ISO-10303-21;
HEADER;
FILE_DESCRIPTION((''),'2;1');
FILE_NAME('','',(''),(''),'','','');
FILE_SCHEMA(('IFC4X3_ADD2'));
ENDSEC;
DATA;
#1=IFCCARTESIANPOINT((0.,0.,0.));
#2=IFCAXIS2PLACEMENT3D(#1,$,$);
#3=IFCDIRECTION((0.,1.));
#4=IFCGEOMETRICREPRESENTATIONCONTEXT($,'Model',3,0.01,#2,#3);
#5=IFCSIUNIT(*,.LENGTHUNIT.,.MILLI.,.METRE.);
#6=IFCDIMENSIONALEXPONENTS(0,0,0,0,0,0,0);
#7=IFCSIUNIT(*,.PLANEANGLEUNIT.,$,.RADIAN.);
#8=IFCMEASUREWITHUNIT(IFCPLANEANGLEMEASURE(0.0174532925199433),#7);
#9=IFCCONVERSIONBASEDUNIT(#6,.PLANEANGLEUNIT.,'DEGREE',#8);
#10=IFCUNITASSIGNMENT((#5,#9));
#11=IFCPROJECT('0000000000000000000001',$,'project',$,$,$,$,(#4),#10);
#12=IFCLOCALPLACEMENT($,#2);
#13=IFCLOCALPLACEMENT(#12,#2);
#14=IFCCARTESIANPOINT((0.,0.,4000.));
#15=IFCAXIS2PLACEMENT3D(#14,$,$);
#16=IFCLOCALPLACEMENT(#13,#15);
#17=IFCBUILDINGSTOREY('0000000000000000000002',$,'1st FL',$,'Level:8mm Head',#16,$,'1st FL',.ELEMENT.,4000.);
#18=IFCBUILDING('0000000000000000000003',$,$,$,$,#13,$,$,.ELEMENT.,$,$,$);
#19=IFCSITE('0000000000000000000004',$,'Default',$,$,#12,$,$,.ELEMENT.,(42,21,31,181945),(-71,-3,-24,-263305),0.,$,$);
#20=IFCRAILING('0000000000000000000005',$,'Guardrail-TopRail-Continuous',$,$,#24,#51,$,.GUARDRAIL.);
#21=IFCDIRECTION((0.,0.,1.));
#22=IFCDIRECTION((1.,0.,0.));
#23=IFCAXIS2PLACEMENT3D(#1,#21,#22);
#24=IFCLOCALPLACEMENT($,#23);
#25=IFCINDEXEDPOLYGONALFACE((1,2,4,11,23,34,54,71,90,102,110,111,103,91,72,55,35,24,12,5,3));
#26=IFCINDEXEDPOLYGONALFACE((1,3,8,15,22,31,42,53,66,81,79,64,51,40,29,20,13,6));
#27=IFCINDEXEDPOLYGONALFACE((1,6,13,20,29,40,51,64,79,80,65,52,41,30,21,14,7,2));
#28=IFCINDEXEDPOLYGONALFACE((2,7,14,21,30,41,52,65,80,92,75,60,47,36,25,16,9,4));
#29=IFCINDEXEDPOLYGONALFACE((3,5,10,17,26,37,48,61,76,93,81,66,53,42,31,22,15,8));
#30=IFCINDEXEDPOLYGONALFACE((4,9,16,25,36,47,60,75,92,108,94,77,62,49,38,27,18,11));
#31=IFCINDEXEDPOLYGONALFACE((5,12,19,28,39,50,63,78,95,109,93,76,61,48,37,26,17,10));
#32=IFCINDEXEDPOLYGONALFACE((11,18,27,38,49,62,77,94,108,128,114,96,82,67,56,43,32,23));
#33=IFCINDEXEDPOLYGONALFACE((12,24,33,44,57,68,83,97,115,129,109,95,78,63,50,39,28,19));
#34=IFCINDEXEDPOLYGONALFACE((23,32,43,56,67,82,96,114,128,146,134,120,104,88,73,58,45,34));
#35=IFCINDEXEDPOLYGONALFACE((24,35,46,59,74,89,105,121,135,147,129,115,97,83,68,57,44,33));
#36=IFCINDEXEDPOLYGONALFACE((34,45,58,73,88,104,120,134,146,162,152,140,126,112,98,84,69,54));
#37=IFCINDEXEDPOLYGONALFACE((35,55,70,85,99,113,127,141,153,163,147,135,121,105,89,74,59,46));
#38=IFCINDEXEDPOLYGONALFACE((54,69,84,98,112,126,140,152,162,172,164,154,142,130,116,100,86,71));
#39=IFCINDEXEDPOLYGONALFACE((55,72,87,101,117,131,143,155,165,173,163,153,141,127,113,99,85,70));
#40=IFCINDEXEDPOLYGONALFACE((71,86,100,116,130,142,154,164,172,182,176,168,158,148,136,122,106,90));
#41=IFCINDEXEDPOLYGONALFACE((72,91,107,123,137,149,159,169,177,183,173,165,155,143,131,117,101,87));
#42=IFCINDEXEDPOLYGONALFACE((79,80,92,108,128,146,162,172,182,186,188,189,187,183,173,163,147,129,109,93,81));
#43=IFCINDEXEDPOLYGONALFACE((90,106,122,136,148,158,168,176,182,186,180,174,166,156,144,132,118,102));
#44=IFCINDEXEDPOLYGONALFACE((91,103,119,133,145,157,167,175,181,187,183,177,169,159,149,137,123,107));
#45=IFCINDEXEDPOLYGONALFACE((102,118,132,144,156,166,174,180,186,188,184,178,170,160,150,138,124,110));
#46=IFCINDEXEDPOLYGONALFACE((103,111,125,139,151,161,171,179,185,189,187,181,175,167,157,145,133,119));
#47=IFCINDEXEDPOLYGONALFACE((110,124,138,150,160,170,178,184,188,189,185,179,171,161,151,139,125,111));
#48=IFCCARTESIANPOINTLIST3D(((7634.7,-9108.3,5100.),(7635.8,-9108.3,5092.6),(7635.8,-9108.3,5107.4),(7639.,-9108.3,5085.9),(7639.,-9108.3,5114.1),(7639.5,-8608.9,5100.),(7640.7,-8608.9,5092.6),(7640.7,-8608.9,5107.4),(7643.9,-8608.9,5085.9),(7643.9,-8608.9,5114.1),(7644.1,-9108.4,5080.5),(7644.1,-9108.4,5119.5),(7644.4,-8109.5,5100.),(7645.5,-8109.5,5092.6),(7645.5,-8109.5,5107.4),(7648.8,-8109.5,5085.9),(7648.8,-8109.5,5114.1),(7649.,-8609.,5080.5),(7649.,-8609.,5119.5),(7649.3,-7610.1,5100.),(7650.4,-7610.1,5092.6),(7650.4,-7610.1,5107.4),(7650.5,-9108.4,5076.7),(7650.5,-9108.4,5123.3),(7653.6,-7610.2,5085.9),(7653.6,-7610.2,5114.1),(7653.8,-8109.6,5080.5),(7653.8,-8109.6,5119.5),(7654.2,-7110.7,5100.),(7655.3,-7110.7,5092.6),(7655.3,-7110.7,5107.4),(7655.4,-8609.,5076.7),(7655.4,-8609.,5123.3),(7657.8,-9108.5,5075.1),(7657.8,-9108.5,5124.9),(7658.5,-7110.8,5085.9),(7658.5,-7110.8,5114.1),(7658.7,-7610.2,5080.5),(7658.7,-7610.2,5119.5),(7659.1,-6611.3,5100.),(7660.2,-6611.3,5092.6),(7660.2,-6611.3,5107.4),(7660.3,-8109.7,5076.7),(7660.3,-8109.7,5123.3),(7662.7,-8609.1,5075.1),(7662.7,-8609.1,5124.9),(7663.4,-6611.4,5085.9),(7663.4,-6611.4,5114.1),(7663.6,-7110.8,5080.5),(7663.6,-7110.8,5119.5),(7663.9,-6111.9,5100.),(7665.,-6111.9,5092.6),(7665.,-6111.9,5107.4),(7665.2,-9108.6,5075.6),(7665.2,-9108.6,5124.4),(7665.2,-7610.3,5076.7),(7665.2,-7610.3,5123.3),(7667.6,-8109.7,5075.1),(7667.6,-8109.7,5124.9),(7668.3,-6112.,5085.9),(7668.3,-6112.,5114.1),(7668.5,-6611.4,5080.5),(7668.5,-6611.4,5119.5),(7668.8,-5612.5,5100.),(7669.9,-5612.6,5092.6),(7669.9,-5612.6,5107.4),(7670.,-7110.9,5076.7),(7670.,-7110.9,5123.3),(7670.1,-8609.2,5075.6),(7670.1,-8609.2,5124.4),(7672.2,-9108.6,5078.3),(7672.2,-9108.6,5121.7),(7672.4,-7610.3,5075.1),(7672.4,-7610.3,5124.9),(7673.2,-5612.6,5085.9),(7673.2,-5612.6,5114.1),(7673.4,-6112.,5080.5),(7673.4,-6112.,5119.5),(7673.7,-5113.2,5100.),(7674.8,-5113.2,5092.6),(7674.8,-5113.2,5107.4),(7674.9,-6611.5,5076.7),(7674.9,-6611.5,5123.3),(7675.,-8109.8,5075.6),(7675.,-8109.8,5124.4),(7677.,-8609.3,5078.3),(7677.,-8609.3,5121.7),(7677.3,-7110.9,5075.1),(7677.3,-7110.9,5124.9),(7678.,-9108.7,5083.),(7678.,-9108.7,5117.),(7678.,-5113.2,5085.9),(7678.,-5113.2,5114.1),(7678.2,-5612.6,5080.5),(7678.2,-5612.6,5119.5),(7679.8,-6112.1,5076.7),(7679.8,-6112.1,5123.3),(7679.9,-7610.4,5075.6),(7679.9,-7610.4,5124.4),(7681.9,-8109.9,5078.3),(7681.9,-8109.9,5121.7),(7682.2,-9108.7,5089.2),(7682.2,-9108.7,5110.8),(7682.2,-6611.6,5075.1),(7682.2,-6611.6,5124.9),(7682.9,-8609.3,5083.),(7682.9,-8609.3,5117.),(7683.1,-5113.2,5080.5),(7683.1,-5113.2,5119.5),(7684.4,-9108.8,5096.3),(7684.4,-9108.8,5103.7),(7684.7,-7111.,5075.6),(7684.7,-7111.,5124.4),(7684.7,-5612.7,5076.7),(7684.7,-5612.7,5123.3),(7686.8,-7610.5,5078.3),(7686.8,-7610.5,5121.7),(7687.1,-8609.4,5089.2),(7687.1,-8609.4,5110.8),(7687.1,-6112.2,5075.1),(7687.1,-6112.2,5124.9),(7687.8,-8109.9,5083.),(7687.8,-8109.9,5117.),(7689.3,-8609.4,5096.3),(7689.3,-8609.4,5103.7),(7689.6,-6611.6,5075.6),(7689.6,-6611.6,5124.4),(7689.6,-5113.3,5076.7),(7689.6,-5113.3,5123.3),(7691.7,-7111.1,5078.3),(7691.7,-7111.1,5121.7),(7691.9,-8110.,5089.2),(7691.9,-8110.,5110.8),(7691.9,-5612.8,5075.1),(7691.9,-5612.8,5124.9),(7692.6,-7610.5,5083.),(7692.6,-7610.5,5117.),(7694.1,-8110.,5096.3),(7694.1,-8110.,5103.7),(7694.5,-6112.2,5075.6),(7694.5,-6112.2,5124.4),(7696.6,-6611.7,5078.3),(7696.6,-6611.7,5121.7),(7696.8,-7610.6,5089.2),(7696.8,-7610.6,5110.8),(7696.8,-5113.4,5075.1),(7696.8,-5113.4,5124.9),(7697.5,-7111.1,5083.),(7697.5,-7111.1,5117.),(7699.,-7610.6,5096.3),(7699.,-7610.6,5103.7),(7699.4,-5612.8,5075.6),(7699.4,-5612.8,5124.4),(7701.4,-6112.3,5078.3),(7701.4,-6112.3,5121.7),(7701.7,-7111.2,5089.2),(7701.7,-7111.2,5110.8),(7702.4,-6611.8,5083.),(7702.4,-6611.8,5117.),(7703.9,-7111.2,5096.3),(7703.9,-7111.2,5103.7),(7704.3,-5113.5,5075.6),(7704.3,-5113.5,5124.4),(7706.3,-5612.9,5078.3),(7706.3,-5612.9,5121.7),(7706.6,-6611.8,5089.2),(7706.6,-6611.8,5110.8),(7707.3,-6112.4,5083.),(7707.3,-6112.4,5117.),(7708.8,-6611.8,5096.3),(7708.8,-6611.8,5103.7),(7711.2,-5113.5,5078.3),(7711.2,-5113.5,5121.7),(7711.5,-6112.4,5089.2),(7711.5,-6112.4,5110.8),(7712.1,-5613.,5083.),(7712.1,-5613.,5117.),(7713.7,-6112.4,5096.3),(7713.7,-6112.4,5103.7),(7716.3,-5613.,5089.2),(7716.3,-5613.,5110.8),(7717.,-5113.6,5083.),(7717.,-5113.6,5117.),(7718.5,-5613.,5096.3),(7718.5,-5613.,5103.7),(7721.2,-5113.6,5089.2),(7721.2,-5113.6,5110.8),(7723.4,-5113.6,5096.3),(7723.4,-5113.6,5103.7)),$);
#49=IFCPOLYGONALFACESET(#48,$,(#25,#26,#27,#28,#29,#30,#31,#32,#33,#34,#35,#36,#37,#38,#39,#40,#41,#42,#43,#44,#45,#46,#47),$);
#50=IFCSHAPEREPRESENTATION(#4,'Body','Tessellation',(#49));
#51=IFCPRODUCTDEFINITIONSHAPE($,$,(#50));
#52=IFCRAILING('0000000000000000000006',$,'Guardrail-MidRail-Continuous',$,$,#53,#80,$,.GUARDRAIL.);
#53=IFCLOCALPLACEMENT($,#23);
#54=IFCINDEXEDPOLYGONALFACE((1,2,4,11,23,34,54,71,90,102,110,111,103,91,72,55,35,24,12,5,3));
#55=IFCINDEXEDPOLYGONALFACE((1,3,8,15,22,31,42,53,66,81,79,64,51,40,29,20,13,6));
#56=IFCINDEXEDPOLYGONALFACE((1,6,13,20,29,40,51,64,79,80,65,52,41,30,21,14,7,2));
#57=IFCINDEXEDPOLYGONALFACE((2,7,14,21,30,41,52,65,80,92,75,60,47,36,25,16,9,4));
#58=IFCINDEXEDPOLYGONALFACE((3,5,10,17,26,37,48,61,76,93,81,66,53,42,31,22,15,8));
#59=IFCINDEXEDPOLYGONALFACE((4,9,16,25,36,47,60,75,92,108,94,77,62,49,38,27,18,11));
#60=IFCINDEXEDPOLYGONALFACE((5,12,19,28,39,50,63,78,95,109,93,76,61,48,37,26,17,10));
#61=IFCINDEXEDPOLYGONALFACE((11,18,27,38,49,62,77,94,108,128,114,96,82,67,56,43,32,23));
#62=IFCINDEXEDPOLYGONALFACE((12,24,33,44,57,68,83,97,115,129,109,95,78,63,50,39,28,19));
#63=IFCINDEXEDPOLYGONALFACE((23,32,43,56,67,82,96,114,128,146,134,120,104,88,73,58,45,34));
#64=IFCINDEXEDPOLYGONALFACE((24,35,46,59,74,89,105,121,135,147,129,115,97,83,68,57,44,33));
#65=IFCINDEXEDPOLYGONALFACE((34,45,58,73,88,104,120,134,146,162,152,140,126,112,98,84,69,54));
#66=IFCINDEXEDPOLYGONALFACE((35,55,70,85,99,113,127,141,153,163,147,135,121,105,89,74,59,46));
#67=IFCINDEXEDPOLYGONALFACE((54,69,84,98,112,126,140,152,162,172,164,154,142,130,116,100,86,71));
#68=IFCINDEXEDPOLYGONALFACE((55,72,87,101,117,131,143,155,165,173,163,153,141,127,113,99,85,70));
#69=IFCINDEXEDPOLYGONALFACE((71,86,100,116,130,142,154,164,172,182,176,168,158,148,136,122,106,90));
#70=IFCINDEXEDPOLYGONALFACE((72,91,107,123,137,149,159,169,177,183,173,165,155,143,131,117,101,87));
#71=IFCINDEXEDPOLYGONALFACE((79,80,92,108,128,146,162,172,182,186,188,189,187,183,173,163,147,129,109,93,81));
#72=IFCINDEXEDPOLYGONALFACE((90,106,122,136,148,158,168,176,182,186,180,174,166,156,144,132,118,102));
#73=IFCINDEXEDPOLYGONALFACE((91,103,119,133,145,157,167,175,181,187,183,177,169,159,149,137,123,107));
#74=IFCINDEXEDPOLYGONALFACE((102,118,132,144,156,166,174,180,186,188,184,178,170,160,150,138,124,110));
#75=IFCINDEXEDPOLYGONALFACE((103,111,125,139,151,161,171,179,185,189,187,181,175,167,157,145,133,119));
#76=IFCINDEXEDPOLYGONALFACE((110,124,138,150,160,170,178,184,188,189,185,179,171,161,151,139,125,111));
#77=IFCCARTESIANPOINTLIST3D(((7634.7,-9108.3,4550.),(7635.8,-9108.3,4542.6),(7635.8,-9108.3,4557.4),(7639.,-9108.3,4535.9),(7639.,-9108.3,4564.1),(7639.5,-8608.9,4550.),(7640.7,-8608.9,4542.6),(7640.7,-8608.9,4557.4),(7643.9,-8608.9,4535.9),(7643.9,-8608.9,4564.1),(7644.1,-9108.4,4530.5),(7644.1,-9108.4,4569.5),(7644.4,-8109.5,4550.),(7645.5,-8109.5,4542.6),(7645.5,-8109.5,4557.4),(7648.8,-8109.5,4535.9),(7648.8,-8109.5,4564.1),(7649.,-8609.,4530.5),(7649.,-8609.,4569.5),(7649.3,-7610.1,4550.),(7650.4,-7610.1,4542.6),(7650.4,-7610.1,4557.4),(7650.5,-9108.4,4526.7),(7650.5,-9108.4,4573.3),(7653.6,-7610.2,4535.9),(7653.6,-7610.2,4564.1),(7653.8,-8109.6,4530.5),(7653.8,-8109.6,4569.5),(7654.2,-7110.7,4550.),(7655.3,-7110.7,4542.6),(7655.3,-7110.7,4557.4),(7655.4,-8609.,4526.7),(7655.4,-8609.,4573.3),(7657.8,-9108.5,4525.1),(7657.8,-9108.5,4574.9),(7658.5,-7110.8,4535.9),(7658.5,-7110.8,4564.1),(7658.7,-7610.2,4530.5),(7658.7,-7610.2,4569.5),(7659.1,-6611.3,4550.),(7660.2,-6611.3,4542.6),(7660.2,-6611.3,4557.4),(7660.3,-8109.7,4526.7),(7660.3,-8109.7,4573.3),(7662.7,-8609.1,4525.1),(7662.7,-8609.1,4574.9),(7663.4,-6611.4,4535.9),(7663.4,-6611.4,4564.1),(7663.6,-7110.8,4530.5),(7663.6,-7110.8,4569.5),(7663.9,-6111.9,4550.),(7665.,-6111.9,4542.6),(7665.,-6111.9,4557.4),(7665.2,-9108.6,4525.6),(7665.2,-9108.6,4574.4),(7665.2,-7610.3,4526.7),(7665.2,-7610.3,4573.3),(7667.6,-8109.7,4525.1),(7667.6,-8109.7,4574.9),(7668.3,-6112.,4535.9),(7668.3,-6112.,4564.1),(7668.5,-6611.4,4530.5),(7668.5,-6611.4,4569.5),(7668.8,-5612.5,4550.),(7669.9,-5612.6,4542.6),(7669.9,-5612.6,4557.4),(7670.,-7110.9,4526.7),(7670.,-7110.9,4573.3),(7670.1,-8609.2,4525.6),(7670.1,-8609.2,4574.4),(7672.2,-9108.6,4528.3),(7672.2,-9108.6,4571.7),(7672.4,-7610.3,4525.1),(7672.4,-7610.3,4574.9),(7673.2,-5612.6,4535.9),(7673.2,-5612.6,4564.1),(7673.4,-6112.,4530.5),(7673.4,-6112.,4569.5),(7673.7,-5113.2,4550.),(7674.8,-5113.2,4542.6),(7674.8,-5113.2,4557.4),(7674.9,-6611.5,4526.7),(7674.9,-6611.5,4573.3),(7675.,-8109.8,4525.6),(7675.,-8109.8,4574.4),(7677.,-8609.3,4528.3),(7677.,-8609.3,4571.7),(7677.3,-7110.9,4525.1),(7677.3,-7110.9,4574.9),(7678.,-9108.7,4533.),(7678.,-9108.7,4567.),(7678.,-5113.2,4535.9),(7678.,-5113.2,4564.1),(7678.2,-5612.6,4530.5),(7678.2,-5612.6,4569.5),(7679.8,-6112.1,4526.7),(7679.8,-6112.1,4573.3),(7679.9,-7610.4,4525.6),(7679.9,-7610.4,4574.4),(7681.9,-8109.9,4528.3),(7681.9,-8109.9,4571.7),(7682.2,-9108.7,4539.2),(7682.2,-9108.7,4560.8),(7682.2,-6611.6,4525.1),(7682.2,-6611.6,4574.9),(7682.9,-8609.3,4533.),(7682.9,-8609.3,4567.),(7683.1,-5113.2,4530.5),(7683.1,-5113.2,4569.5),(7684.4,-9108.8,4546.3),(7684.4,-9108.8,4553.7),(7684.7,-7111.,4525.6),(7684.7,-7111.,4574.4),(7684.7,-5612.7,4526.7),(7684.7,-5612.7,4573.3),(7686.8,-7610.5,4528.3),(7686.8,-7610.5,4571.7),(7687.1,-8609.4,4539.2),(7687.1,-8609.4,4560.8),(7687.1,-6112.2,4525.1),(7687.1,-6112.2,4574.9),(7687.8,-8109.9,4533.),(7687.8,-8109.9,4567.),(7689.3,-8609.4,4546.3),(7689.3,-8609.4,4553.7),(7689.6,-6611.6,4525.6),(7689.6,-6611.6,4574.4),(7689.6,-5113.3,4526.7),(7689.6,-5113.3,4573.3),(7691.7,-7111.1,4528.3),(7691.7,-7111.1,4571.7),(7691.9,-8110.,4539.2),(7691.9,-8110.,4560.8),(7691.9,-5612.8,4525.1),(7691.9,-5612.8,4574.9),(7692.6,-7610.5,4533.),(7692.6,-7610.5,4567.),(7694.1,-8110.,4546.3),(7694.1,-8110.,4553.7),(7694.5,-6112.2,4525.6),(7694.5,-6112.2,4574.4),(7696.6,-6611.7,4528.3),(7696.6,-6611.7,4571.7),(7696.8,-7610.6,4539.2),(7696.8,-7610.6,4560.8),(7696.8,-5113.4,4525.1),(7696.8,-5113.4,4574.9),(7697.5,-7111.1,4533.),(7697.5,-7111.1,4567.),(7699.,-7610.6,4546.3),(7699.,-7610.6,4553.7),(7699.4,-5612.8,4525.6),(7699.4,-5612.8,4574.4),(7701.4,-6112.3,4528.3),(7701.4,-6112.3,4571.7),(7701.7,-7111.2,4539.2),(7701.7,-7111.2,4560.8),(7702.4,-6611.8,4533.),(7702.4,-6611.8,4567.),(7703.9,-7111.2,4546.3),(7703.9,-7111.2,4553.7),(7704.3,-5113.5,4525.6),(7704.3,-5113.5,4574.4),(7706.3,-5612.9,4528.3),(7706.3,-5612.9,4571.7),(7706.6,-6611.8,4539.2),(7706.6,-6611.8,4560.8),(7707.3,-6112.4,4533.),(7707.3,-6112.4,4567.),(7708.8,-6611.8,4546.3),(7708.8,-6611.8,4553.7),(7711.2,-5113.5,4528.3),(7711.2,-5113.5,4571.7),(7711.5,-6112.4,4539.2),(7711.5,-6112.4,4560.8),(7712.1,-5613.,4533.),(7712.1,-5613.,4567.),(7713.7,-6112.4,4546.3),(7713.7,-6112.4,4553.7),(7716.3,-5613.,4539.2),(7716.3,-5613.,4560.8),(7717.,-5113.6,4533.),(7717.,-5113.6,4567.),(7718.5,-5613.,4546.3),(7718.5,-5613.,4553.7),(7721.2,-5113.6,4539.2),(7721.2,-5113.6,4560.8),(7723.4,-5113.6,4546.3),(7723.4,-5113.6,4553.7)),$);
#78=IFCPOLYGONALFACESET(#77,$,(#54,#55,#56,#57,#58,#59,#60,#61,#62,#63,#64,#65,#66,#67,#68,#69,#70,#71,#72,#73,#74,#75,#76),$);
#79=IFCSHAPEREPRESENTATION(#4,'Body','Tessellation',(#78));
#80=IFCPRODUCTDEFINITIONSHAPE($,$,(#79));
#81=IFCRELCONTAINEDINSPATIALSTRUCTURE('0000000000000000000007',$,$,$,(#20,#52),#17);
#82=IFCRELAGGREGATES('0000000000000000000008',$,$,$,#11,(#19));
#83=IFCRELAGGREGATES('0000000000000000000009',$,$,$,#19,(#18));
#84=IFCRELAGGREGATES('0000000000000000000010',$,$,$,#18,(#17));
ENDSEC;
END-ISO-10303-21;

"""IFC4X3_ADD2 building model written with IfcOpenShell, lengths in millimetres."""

from ifc_helpers import new_model, entity, si_unit, converted_unit, direction, frame, origin, origin_with_axes, place, context, project, spatial, element, save


model = new_model("IFC4X3_ADD2")

# Units and contexts
model_context = context("Model", 3, precision=0.01, world=origin(), true_north=direction((0.0, 1.0)))
ifc_project = project(units=[si_unit("LENGTHUNIT", "METRE", prefix="MILLI"), converted_unit("PLANEANGLEUNIT", "DEGREE", entity("IfcPlaneAngleMeasure", 0.0174532925199433), si_unit("PLANEANGLEUNIT", "RADIAN"), dimensions=[0, 0, 0, 0, 0, 0, 0])], contexts=[model_context])

# Site, building, storey
site_placement = place(None, origin())
site = spatial("IfcSite", under=ifc_project, at=site_placement, Name="Default", CompositionType="ELEMENT", RefLatitude=(42, 21, 31, 181945), RefLongitude=(-71, -3, -24, -263305), RefElevation=0.0)
building_placement = place(site_placement, origin())
building = spatial("IfcBuilding", under=site, at=building_placement, CompositionType="ELEMENT")
storey_placement = place(building_placement, frame((0.0, 0.0, 4000.0)))
storey = spatial("IfcBuildingStorey", under=building, at=storey_placement, Name="1st FL", ObjectType="Level:8mm Head", LongName="1st FL", CompositionType="ELEMENT", Elevation=4000.0)

# Railings
railing_1_placement = place(None, origin_with_axes())
element("IfcRailing", 1, at=railing_1_placement, inside=storey, Name="Guardrail-TopRail-Continuous", PredefinedType="GUARDRAIL", context=model_context, shape_type="SweptSolid", body=[
    entity("IfcSweptDiskSolid", entity("IfcPolyline", [entity("IfcCartesianPoint", [7698.7, -5113.4, 5100.0]), entity("IfcCartesianPoint", [7693.8, -5612.8, 5100.0]), entity("IfcCartesianPoint", [7688.9, -6112.2, 5100.0]), entity("IfcCartesianPoint", [7684.1, -6611.6, 5100.0]), entity("IfcCartesianPoint", [7679.2, -7111.0, 5100.0]), entity("IfcCartesianPoint", [7674.3, -7610.4, 5100.0]), entity("IfcCartesianPoint", [7669.4, -8109.7, 5100.0]), entity("IfcCartesianPoint", [7664.5, -8609.1, 5100.0]), entity("IfcCartesianPoint", [7659.7, -9108.5, 5100.0])]), 25.0),
])
railing_2_placement = place(None, origin_with_axes())
element("IfcRailing", 2, at=railing_2_placement, inside=storey, Name="Guardrail-MidRail-Continuous", PredefinedType="GUARDRAIL", context=model_context, shape_type="SweptSolid", body=[
    entity("IfcSweptDiskSolid", entity("IfcPolyline", [entity("IfcCartesianPoint", [7698.7, -5113.4, 4550.0]), entity("IfcCartesianPoint", [7693.8, -5612.8, 4550.0]), entity("IfcCartesianPoint", [7688.9, -6112.2, 4550.0]), entity("IfcCartesianPoint", [7684.1, -6611.6, 4550.0]), entity("IfcCartesianPoint", [7679.2, -7111.0, 4550.0]), entity("IfcCartesianPoint", [7674.3, -7610.4, 4550.0]), entity("IfcCartesianPoint", [7669.4, -8109.7, 4550.0]), entity("IfcCartesianPoint", [7664.5, -8609.1, 4550.0]), entity("IfcCartesianPoint", [7659.7, -9108.5, 4550.0])]), 25.0),
])

save(model, "model.ifc")
